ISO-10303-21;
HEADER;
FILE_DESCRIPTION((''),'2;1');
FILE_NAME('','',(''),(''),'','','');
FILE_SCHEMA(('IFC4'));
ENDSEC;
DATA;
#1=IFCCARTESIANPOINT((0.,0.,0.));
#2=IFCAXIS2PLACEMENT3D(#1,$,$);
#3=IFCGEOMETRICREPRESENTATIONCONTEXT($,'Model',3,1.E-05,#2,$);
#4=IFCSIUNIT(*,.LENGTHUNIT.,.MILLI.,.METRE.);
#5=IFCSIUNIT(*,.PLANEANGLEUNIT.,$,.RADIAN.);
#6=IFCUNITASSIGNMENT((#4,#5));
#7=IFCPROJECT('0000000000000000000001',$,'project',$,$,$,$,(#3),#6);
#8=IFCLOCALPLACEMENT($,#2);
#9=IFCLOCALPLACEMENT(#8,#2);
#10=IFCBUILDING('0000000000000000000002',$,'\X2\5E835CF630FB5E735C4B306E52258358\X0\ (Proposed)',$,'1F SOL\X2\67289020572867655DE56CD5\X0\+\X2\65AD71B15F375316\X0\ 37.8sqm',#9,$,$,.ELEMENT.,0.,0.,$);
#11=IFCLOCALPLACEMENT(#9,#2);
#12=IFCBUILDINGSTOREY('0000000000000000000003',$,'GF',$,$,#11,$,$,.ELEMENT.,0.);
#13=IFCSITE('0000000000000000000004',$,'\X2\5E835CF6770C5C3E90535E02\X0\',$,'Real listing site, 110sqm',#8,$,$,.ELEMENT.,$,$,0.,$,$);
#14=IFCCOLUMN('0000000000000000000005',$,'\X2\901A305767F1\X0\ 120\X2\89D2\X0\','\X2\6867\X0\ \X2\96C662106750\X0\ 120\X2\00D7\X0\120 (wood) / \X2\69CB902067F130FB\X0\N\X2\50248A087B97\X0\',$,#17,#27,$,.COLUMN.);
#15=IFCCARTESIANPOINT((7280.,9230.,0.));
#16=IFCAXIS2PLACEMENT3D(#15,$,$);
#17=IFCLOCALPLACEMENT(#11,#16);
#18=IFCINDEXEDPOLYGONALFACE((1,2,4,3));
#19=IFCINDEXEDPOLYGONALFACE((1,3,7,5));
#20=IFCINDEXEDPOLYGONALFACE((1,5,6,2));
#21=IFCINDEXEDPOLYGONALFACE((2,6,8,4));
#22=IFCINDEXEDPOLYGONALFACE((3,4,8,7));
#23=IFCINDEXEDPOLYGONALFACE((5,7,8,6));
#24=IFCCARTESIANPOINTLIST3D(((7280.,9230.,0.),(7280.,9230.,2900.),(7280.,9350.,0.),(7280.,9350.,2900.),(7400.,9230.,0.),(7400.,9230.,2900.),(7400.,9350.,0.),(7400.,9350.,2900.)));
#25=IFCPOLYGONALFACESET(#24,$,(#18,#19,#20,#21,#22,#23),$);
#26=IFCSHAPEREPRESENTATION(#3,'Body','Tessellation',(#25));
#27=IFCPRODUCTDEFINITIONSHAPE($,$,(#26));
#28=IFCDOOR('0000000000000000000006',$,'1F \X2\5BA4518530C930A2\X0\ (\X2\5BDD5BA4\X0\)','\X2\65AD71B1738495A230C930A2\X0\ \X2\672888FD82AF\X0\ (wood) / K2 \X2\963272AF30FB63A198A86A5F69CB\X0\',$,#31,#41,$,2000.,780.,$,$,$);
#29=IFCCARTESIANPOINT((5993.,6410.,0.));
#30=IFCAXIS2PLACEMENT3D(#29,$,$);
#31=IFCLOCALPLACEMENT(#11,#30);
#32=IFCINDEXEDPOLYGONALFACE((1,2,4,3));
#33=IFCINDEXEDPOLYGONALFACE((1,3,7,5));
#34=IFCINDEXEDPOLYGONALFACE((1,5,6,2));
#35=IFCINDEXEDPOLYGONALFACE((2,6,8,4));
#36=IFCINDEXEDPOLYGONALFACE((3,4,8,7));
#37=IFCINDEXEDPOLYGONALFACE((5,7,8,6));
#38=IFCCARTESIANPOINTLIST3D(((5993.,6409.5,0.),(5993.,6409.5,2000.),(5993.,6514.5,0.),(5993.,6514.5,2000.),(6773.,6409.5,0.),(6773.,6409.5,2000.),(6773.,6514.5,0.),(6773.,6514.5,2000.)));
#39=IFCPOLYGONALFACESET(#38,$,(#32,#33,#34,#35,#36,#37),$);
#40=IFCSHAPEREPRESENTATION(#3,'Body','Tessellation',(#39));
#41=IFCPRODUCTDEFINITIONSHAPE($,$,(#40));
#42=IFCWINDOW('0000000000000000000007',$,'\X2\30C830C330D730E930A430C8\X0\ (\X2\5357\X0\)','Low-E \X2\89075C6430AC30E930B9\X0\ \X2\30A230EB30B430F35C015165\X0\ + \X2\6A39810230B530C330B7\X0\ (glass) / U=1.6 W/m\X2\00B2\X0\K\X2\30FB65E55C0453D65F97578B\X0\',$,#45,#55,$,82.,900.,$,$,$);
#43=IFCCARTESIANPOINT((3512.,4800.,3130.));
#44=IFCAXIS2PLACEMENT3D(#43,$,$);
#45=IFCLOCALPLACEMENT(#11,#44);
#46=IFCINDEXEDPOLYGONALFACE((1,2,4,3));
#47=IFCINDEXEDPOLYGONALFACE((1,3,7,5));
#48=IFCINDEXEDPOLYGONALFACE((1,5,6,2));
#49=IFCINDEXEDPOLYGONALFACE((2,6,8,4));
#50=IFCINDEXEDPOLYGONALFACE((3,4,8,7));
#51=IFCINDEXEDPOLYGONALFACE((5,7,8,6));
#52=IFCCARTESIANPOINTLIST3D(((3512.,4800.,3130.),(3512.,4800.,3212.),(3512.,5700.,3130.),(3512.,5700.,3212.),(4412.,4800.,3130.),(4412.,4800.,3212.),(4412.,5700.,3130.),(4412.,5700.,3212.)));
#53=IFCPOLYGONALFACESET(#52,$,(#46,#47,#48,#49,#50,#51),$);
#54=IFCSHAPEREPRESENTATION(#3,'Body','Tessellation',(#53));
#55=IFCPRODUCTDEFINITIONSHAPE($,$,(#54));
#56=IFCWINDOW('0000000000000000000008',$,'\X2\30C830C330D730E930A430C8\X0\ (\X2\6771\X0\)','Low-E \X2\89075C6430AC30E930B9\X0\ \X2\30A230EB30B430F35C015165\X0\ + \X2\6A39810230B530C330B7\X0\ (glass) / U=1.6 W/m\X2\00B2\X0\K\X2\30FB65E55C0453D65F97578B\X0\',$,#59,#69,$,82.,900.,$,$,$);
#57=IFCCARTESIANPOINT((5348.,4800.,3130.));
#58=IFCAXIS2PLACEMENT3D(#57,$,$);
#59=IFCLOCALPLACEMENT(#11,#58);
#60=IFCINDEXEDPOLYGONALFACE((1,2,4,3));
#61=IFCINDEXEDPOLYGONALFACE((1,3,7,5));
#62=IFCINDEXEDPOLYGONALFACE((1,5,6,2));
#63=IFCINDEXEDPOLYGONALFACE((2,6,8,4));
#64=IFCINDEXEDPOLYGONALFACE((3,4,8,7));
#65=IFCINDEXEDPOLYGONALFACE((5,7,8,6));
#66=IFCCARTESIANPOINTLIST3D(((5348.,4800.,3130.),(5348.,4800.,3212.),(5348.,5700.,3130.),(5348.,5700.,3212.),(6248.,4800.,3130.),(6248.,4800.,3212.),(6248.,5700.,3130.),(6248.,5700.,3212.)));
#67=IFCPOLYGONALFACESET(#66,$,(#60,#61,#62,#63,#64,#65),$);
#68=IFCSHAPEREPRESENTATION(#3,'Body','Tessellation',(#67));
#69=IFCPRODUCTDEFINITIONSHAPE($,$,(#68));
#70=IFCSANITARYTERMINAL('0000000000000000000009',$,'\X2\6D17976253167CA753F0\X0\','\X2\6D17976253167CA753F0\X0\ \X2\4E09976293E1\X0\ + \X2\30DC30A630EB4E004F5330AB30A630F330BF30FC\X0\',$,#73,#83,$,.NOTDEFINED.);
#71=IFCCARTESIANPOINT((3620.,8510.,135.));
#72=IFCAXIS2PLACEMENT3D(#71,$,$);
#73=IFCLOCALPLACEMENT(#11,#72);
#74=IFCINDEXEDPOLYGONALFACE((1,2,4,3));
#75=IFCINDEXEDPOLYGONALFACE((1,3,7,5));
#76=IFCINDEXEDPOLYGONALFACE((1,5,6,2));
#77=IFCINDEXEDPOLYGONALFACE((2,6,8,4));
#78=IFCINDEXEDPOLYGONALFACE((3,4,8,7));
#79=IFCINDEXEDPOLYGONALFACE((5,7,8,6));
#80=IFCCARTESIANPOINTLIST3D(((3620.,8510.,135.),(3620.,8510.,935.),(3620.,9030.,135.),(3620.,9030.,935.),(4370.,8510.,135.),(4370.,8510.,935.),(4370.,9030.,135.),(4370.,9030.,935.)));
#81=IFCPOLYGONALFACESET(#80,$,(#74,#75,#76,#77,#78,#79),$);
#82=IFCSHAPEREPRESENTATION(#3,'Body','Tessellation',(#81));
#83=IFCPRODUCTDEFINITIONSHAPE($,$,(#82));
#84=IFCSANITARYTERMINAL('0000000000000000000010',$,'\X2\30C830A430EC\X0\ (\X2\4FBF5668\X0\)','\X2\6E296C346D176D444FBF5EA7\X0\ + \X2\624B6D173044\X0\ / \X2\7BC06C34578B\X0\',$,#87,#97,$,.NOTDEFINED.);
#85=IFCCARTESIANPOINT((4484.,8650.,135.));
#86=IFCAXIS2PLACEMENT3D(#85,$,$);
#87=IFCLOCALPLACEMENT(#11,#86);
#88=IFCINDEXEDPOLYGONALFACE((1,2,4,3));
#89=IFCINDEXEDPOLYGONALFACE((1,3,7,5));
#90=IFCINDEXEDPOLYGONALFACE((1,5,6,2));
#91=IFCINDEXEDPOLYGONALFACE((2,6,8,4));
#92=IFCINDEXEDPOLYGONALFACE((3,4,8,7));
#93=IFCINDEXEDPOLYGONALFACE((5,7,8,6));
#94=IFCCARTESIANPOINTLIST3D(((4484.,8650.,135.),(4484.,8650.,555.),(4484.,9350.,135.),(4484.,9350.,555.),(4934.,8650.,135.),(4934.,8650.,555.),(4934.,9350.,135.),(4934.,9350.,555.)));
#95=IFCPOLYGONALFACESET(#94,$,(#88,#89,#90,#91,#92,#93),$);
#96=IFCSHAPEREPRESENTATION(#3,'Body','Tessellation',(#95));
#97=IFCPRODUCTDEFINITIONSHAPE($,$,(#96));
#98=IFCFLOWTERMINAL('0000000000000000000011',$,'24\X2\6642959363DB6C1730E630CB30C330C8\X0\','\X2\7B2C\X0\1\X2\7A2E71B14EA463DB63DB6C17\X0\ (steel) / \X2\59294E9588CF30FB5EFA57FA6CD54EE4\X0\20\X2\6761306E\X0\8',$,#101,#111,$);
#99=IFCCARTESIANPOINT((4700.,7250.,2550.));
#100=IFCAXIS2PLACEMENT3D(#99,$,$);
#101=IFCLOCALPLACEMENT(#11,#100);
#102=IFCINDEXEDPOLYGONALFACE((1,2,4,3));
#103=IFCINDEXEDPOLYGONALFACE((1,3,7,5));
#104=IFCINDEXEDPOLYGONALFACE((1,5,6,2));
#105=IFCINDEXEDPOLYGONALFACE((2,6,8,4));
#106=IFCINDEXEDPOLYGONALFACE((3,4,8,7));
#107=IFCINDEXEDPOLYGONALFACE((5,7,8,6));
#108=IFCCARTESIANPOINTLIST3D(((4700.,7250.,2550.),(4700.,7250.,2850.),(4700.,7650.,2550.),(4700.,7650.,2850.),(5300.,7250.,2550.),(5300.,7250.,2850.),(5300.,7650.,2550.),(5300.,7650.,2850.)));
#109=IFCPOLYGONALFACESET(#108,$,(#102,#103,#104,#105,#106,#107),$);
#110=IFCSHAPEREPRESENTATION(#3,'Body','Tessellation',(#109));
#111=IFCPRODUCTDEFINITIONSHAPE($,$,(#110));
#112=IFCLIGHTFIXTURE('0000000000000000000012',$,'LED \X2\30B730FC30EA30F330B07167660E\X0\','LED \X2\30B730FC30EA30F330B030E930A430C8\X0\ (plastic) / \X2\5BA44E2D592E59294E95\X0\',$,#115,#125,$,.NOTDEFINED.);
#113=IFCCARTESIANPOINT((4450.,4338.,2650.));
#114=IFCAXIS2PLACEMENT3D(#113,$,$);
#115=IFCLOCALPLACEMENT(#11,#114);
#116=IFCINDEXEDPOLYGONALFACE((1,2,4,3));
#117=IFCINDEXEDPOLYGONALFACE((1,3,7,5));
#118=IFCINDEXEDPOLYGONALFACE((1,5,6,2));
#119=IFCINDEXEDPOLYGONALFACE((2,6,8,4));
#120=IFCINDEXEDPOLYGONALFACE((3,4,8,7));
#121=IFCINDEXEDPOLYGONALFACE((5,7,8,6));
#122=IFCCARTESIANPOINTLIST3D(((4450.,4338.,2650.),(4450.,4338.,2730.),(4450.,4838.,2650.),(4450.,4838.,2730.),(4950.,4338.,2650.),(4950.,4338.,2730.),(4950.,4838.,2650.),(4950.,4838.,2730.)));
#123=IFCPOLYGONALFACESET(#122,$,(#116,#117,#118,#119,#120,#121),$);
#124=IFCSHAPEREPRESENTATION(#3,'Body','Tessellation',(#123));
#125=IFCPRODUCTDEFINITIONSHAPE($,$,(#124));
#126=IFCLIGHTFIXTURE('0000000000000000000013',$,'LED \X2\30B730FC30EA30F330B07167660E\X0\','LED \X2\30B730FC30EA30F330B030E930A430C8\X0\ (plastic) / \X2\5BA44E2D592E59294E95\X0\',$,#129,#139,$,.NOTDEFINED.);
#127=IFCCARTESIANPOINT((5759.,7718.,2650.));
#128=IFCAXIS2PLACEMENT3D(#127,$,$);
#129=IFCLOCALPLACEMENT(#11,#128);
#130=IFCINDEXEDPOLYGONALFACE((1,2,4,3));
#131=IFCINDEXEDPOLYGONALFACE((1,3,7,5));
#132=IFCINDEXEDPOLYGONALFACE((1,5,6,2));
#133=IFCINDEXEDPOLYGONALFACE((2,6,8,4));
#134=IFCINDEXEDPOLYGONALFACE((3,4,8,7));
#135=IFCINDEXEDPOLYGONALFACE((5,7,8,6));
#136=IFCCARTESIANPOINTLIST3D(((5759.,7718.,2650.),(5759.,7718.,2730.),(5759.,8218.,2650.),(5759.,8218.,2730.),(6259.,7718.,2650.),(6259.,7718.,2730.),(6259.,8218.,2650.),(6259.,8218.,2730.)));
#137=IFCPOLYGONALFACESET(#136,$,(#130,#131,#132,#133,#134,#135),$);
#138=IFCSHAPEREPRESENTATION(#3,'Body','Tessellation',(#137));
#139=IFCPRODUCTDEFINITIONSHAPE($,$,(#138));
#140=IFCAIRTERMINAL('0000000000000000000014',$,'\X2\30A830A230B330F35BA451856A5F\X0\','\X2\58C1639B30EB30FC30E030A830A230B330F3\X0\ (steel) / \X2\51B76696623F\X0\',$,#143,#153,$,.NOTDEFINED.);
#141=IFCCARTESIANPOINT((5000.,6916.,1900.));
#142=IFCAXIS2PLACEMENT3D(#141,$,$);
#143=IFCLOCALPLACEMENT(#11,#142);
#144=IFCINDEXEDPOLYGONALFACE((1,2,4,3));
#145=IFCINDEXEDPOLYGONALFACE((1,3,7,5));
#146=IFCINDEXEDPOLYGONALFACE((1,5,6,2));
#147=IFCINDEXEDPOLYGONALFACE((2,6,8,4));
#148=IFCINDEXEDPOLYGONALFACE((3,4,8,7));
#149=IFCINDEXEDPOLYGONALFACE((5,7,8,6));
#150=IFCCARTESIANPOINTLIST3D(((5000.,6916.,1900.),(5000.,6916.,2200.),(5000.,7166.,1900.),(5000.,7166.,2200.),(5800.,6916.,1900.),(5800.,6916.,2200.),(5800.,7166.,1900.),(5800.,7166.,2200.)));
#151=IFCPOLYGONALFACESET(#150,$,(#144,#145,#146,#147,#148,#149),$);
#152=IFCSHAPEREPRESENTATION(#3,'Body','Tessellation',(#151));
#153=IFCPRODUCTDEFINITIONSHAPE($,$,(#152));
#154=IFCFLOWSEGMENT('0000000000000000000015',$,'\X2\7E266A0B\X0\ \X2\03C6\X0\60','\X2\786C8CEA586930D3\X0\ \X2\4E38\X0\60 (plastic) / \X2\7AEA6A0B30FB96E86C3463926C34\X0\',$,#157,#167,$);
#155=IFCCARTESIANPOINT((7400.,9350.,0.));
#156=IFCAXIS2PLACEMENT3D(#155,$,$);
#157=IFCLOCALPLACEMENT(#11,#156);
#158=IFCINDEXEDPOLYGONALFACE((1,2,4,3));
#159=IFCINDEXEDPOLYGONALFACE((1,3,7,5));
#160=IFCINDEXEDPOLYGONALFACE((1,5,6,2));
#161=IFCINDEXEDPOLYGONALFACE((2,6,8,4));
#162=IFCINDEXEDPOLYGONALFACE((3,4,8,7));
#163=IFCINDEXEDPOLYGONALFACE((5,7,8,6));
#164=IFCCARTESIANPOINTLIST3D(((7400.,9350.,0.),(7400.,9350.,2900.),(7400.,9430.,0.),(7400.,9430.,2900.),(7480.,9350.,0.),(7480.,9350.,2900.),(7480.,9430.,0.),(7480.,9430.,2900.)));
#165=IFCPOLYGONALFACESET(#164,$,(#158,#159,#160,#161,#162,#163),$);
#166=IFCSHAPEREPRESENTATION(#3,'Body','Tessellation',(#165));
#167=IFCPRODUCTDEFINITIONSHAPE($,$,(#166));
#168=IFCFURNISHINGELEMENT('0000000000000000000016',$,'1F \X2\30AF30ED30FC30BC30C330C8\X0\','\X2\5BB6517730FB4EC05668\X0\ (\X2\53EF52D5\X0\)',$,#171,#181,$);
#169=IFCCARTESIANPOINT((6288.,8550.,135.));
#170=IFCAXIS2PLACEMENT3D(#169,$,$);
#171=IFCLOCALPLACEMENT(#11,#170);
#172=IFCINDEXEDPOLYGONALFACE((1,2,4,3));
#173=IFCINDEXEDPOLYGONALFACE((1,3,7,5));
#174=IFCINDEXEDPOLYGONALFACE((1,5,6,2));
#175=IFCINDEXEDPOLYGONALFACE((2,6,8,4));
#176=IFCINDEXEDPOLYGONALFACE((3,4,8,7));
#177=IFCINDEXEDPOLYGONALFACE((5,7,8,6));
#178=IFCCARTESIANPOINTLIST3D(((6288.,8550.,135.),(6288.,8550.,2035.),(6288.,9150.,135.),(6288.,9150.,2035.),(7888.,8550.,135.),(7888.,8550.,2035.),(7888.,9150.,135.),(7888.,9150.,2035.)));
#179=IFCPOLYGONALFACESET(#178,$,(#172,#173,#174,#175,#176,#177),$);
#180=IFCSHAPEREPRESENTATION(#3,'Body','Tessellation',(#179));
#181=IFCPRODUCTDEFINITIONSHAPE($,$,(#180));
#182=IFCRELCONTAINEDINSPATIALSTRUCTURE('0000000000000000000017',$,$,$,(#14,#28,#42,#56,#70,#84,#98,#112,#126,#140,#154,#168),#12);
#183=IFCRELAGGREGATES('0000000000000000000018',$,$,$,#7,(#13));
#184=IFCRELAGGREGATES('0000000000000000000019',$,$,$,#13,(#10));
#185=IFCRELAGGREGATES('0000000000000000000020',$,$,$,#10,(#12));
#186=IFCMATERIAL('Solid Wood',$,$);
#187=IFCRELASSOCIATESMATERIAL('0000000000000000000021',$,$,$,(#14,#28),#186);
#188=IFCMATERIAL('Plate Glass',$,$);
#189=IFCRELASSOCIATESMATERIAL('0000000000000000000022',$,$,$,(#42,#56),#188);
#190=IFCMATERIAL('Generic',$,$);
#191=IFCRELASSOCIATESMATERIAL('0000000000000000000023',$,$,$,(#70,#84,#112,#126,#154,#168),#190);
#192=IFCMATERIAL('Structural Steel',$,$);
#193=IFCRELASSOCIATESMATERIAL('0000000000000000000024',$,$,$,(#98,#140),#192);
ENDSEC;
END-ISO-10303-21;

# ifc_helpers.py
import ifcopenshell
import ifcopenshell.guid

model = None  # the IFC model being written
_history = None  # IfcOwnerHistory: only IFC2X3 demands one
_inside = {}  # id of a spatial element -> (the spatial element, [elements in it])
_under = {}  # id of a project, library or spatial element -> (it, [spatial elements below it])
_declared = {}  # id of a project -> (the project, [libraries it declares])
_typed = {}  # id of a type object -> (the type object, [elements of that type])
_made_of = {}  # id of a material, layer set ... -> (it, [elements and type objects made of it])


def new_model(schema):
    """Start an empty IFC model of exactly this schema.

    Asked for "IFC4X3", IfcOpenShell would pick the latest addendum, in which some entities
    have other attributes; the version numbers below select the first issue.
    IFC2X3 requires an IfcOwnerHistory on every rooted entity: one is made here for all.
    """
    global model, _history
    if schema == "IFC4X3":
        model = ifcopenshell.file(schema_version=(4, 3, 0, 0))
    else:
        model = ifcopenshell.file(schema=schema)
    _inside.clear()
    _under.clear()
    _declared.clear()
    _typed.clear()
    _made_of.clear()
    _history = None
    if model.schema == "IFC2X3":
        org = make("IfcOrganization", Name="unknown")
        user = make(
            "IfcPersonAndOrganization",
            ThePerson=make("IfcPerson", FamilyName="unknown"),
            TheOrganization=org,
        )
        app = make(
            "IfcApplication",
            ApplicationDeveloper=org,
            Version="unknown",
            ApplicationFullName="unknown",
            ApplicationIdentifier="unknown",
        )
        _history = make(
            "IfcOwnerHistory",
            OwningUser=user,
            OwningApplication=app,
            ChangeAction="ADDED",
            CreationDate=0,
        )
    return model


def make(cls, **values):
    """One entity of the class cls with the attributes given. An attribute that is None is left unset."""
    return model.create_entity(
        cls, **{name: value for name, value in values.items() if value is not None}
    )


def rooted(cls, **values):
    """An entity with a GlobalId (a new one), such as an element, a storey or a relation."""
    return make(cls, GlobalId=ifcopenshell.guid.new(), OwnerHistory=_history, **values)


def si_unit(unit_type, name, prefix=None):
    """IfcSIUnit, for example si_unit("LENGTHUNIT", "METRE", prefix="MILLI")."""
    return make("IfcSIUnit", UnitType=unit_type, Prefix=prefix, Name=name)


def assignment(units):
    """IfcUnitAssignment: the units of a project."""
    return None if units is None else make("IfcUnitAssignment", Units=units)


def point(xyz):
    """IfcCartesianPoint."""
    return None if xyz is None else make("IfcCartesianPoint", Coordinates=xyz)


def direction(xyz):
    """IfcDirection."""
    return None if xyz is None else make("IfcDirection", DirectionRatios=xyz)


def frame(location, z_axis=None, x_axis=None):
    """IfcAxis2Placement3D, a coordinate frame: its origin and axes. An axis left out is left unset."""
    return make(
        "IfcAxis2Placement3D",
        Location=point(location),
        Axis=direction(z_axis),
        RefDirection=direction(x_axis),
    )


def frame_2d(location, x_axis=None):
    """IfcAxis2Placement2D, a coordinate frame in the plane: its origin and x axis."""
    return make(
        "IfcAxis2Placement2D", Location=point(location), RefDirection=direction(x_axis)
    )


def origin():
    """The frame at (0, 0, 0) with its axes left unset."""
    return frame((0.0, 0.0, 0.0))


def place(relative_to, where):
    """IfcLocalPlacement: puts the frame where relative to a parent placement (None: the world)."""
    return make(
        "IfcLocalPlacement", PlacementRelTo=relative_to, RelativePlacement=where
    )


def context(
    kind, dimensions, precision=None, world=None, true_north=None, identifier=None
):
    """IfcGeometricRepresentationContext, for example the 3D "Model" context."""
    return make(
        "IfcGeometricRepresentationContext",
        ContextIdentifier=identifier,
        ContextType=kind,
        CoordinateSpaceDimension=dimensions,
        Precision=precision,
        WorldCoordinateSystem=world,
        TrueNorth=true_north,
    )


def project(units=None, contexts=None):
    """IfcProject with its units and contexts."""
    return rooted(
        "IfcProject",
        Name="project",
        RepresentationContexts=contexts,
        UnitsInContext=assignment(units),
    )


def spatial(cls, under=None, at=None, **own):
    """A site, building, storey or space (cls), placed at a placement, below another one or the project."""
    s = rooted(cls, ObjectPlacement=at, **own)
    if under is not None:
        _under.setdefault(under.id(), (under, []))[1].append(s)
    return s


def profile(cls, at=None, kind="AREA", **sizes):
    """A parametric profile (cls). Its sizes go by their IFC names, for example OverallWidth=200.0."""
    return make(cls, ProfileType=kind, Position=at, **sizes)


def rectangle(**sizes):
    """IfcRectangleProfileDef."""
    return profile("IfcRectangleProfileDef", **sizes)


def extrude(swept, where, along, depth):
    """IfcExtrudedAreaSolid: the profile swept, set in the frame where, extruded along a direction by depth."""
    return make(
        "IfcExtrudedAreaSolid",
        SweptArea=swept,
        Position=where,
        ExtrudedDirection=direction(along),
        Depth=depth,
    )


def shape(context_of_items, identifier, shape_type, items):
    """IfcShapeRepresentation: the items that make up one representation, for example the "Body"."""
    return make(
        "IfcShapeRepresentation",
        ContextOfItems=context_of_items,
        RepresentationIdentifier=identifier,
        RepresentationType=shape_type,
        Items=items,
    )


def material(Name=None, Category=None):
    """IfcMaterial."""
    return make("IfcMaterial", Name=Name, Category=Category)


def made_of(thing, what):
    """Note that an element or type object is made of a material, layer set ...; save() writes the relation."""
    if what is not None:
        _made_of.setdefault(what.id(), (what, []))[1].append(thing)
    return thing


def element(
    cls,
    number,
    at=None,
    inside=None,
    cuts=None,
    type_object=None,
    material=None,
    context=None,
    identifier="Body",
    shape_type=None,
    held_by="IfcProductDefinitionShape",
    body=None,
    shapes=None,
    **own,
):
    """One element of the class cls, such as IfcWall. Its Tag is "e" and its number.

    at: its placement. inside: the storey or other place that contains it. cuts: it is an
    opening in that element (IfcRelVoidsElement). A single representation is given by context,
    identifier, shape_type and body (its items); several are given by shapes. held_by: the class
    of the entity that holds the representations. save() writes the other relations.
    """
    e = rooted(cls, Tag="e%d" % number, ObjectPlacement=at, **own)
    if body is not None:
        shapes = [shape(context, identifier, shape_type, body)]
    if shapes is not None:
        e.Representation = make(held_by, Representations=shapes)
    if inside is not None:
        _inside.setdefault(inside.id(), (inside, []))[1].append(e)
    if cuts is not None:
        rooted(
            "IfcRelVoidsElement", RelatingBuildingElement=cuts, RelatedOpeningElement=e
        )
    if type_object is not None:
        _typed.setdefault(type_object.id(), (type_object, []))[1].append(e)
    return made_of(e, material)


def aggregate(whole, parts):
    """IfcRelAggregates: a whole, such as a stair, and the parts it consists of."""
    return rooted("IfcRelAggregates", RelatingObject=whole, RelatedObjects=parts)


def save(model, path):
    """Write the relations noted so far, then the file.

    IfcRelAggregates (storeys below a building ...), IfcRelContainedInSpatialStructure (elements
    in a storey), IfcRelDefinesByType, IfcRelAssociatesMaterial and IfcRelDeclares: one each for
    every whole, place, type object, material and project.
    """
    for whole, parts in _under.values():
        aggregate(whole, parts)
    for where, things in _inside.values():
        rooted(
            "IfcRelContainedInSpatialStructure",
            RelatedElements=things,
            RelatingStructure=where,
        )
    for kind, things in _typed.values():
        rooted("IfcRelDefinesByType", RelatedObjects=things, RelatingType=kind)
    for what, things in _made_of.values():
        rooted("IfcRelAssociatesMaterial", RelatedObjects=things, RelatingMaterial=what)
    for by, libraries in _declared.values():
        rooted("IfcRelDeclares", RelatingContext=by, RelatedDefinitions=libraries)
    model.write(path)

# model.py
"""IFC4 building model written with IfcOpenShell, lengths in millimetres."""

from ifc_helpers import new_model, si_unit, frame, frame_2d, origin, place, context, project, spatial, rectangle, extrude, material, element, save


model = new_model("IFC4")

# Units and contexts
model_context = context("Model", 3, precision=1e-05, world=origin())
ifc_project = project(units=[si_unit("LENGTHUNIT", "METRE", prefix="MILLI"), si_unit("PLANEANGLEUNIT", "RADIAN")], contexts=[model_context])

# Site, building, storey
site_placement = place(None, origin())
site = spatial("IfcSite", under=ifc_project, at=site_placement, Name="広島県尾道市", ObjectType="Real listing site, 110sqm", CompositionType="ELEMENT", RefElevation=0.0)
building_placement = place(site_placement, origin())
building = spatial("IfcBuilding", under=site, at=building_placement, Name="広島・平屋の別荘 (Proposed)", ObjectType="1F SOL木造在来工法+断熱強化 37.8sqm", CompositionType="ELEMENT", ElevationOfRefHeight=0.0, ElevationOfTerrain=0.0)
storey_placement = place(building_placement, origin())
storey = spatial("IfcBuildingStorey", under=building, at=storey_placement, Name="GF", CompositionType="ELEMENT", Elevation=0.0)

# Column
ifc_material_1 = material(Name="Solid Wood")
column_1_placement = place(storey_placement, frame((7280.0, 9230.0, 0.0)))
element("IfcColumn", 1, at=column_1_placement, inside=storey, material=ifc_material_1, Name="通し柱 120角", Description="桧 集成材 120×120 (wood) / 構造柱・N値計算", PredefinedType="COLUMN", context=model_context, shape_type="SweptSolid", body=[
    extrude(rectangle(XDim=120.0, YDim=120.0, at=frame_2d((60.0, 60.0))), frame((7280.0, 9230.0, 0.0)), (0.0, 0.0, 1.0), 2900.0),
])

# Door
door_placement = place(storey_placement, frame((5993.0, 6410.0, 0.0)))
element("IfcDoor", 2, at=door_placement, inside=storey, material=ifc_material_1, Name="1F 室内ドア (寝室)", Description="断熱玄関ドア 木製芯 (wood) / K2 防犯・採風機構", OverallHeight=2000.0, OverallWidth=780.0, context=model_context, shape_type="SweptSolid", body=[
    extrude(rectangle(XDim=780.0, YDim=105.0, at=frame_2d((390.0, 52.0))), frame((5993.0, 6410.0, 0.0)), (0.0, 0.0, 1.0), 2000.0),
])

# Windows
ifc_material_2 = material(Name="Plate Glass")
window_1_placement = place(storey_placement, frame((3512.0, 4800.0, 3130.0)))
element("IfcWindow", 3, at=window_1_placement, inside=storey, material=ifc_material_2, Name="トップライト (南)", Description="Low-E 複層ガラス アルゴン封入 + 樹脂サッシ (glass) / U=1.6 W/m²K・日射取得型", OverallHeight=82.0, OverallWidth=900.0, context=model_context, shape_type="SweptSolid", body=[
    extrude(rectangle(XDim=900.0, YDim=900.0, at=frame_2d((450.0, 450.0))), frame((3512.0, 4800.0, 3130.0)), (0.0, 0.0, 1.0), 82.0),
])
window_2_placement = place(storey_placement, frame((5348.0, 4800.0, 3130.0)))
element("IfcWindow", 4, at=window_2_placement, inside=storey, material=ifc_material_2, Name="トップライト (東)", Description="Low-E 複層ガラス アルゴン封入 + 樹脂サッシ (glass) / U=1.6 W/m²K・日射取得型", OverallHeight=82.0, OverallWidth=900.0, context=model_context, shape_type="SweptSolid", body=[
    extrude(rectangle(XDim=900.0, YDim=900.0, at=frame_2d((450.0, 450.0))), frame((5348.0, 4800.0, 3130.0)), (0.0, 0.0, 1.0), 82.0),
])

# Sanitary terminals
ifc_material_3 = material(Name="Generic")
sanitary_terminal_1_placement = place(storey_placement, frame((3620.0, 8510.0, 135.0)))
element("IfcSanitaryTerminal", 5, at=sanitary_terminal_1_placement, inside=storey, material=ifc_material_3, Name="洗面化粧台", Description="洗面化粧台 三面鏡 + ボウル一体カウンター", PredefinedType="NOTDEFINED", context=model_context, shape_type="SweptSolid", body=[
    extrude(rectangle(XDim=750.0, YDim=520.0, at=frame_2d((375.0, 260.0))), frame((3620.0, 8510.0, 135.0)), (0.0, 0.0, 1.0), 800.0),
])
sanitary_terminal_2_placement = place(storey_placement, frame((4484.0, 8650.0, 135.0)))
element("IfcSanitaryTerminal", 6, at=sanitary_terminal_2_placement, inside=storey, material=ifc_material_3, Name="トイレ (便器)", Description="温水洗浄便座 + 手洗い / 節水型", PredefinedType="NOTDEFINED", context=model_context, shape_type="SweptSolid", body=[
    extrude(rectangle(XDim=450.0, YDim=700.0, at=frame_2d((225.0, 350.0))), frame((4484.0, 8650.0, 135.0)), (0.0, 0.0, 1.0), 420.0),
])

# Flow terminal
ifc_material_4 = material(Name="Structural Steel")
flow_terminal_placement = place(storey_placement, frame((4700.0, 7250.0, 2550.0)))
element("IfcFlowTerminal", 7, at=flow_terminal_placement, inside=storey, material=ifc_material_4, Name="24時間換気ユニット", Description="第1種熱交換換気 (steel) / 天井裏・建基法令20条の8", context=model_context, shape_type="SweptSolid", body=[
    extrude(rectangle(XDim=600.0, YDim=400.0, at=frame_2d((300.0, 200.0))), frame((4700.0, 7250.0, 2550.0)), (0.0, 0.0, 1.0), 300.0),
])

# Light fixtures
light_fixture_1_placement = place(storey_placement, frame((4450.0, 4338.0, 2650.0)))
element("IfcLightFixture", 8, at=light_fixture_1_placement, inside=storey, material=ifc_material_3, Name="LED シーリング照明", Description="LED シーリングライト (plastic) / 室中央天井", PredefinedType="NOTDEFINED", context=model_context, shape_type="SweptSolid", body=[
    extrude(rectangle(XDim=500.0, YDim=500.0, at=frame_2d((250.0, 250.0))), frame((4450.0, 4338.0, 2650.0)), (0.0, 0.0, 1.0), 80.0),
])
light_fixture_2_placement = place(storey_placement, frame((5759.0, 7718.0, 2650.0)))
element("IfcLightFixture", 9, at=light_fixture_2_placement, inside=storey, material=ifc_material_3, Name="LED シーリング照明", Description="LED シーリングライト (plastic) / 室中央天井", PredefinedType="NOTDEFINED", context=model_context, shape_type="SweptSolid", body=[
    extrude(rectangle(XDim=500.0, YDim=500.0, at=frame_2d((250.0, 250.0))), frame((5759.0, 7718.0, 2650.0)), (0.0, 0.0, 1.0), 80.0),
])

# Air terminal
air_terminal_placement = place(storey_placement, frame((5000.0, 6916.0, 1900.0)))
element("IfcAirTerminal", 10, at=air_terminal_placement, inside=storey, material=ifc_material_4, Name="エアコン室内機", Description="壁掛ルームエアコン (steel) / 冷暖房", PredefinedType="NOTDEFINED", context=model_context, shape_type="SweptSolid", body=[
    extrude(rectangle(XDim=800.0, YDim=250.0, at=frame_2d((400.0, 125.0))), frame((5000.0, 6916.0, 1900.0)), (0.0, 0.0, 1.0), 300.0),
])

# Flow segment
flow_segment_placement = place(storey_placement, frame((7400.0, 9350.0, 0.0)))
element("IfcFlowSegment", 11, at=flow_segment_placement, inside=storey, material=ifc_material_3, Name="縦樋 φ60", Description="硬質塩ビ 丸60 (plastic) / 竪樋・雨水排水", context=model_context, shape_type="SweptSolid", body=[
    extrude(rectangle(XDim=80.0, YDim=80.0, at=frame_2d((40.0, 40.0))), frame((7400.0, 9350.0, 0.0)), (0.0, 0.0, 1.0), 2900.0),
])

# Furnishing element
furnishing_placement = place(storey_placement, frame((6288.0, 8550.0, 135.0)))
element("IfcFurnishingElement", 12, at=furnishing_placement, inside=storey, material=ifc_material_3, Name="1F クローゼット", Description="家具・什器 (可動)", context=model_context, shape_type="SweptSolid", body=[
    extrude(rectangle(XDim=1600.0, YDim=600.0, at=frame_2d((800.0, 300.0))), frame((6288.0, 8550.0, 135.0)), (0.0, 0.0, 1.0), 1900.0),
])

save(model, "model.ifc")
